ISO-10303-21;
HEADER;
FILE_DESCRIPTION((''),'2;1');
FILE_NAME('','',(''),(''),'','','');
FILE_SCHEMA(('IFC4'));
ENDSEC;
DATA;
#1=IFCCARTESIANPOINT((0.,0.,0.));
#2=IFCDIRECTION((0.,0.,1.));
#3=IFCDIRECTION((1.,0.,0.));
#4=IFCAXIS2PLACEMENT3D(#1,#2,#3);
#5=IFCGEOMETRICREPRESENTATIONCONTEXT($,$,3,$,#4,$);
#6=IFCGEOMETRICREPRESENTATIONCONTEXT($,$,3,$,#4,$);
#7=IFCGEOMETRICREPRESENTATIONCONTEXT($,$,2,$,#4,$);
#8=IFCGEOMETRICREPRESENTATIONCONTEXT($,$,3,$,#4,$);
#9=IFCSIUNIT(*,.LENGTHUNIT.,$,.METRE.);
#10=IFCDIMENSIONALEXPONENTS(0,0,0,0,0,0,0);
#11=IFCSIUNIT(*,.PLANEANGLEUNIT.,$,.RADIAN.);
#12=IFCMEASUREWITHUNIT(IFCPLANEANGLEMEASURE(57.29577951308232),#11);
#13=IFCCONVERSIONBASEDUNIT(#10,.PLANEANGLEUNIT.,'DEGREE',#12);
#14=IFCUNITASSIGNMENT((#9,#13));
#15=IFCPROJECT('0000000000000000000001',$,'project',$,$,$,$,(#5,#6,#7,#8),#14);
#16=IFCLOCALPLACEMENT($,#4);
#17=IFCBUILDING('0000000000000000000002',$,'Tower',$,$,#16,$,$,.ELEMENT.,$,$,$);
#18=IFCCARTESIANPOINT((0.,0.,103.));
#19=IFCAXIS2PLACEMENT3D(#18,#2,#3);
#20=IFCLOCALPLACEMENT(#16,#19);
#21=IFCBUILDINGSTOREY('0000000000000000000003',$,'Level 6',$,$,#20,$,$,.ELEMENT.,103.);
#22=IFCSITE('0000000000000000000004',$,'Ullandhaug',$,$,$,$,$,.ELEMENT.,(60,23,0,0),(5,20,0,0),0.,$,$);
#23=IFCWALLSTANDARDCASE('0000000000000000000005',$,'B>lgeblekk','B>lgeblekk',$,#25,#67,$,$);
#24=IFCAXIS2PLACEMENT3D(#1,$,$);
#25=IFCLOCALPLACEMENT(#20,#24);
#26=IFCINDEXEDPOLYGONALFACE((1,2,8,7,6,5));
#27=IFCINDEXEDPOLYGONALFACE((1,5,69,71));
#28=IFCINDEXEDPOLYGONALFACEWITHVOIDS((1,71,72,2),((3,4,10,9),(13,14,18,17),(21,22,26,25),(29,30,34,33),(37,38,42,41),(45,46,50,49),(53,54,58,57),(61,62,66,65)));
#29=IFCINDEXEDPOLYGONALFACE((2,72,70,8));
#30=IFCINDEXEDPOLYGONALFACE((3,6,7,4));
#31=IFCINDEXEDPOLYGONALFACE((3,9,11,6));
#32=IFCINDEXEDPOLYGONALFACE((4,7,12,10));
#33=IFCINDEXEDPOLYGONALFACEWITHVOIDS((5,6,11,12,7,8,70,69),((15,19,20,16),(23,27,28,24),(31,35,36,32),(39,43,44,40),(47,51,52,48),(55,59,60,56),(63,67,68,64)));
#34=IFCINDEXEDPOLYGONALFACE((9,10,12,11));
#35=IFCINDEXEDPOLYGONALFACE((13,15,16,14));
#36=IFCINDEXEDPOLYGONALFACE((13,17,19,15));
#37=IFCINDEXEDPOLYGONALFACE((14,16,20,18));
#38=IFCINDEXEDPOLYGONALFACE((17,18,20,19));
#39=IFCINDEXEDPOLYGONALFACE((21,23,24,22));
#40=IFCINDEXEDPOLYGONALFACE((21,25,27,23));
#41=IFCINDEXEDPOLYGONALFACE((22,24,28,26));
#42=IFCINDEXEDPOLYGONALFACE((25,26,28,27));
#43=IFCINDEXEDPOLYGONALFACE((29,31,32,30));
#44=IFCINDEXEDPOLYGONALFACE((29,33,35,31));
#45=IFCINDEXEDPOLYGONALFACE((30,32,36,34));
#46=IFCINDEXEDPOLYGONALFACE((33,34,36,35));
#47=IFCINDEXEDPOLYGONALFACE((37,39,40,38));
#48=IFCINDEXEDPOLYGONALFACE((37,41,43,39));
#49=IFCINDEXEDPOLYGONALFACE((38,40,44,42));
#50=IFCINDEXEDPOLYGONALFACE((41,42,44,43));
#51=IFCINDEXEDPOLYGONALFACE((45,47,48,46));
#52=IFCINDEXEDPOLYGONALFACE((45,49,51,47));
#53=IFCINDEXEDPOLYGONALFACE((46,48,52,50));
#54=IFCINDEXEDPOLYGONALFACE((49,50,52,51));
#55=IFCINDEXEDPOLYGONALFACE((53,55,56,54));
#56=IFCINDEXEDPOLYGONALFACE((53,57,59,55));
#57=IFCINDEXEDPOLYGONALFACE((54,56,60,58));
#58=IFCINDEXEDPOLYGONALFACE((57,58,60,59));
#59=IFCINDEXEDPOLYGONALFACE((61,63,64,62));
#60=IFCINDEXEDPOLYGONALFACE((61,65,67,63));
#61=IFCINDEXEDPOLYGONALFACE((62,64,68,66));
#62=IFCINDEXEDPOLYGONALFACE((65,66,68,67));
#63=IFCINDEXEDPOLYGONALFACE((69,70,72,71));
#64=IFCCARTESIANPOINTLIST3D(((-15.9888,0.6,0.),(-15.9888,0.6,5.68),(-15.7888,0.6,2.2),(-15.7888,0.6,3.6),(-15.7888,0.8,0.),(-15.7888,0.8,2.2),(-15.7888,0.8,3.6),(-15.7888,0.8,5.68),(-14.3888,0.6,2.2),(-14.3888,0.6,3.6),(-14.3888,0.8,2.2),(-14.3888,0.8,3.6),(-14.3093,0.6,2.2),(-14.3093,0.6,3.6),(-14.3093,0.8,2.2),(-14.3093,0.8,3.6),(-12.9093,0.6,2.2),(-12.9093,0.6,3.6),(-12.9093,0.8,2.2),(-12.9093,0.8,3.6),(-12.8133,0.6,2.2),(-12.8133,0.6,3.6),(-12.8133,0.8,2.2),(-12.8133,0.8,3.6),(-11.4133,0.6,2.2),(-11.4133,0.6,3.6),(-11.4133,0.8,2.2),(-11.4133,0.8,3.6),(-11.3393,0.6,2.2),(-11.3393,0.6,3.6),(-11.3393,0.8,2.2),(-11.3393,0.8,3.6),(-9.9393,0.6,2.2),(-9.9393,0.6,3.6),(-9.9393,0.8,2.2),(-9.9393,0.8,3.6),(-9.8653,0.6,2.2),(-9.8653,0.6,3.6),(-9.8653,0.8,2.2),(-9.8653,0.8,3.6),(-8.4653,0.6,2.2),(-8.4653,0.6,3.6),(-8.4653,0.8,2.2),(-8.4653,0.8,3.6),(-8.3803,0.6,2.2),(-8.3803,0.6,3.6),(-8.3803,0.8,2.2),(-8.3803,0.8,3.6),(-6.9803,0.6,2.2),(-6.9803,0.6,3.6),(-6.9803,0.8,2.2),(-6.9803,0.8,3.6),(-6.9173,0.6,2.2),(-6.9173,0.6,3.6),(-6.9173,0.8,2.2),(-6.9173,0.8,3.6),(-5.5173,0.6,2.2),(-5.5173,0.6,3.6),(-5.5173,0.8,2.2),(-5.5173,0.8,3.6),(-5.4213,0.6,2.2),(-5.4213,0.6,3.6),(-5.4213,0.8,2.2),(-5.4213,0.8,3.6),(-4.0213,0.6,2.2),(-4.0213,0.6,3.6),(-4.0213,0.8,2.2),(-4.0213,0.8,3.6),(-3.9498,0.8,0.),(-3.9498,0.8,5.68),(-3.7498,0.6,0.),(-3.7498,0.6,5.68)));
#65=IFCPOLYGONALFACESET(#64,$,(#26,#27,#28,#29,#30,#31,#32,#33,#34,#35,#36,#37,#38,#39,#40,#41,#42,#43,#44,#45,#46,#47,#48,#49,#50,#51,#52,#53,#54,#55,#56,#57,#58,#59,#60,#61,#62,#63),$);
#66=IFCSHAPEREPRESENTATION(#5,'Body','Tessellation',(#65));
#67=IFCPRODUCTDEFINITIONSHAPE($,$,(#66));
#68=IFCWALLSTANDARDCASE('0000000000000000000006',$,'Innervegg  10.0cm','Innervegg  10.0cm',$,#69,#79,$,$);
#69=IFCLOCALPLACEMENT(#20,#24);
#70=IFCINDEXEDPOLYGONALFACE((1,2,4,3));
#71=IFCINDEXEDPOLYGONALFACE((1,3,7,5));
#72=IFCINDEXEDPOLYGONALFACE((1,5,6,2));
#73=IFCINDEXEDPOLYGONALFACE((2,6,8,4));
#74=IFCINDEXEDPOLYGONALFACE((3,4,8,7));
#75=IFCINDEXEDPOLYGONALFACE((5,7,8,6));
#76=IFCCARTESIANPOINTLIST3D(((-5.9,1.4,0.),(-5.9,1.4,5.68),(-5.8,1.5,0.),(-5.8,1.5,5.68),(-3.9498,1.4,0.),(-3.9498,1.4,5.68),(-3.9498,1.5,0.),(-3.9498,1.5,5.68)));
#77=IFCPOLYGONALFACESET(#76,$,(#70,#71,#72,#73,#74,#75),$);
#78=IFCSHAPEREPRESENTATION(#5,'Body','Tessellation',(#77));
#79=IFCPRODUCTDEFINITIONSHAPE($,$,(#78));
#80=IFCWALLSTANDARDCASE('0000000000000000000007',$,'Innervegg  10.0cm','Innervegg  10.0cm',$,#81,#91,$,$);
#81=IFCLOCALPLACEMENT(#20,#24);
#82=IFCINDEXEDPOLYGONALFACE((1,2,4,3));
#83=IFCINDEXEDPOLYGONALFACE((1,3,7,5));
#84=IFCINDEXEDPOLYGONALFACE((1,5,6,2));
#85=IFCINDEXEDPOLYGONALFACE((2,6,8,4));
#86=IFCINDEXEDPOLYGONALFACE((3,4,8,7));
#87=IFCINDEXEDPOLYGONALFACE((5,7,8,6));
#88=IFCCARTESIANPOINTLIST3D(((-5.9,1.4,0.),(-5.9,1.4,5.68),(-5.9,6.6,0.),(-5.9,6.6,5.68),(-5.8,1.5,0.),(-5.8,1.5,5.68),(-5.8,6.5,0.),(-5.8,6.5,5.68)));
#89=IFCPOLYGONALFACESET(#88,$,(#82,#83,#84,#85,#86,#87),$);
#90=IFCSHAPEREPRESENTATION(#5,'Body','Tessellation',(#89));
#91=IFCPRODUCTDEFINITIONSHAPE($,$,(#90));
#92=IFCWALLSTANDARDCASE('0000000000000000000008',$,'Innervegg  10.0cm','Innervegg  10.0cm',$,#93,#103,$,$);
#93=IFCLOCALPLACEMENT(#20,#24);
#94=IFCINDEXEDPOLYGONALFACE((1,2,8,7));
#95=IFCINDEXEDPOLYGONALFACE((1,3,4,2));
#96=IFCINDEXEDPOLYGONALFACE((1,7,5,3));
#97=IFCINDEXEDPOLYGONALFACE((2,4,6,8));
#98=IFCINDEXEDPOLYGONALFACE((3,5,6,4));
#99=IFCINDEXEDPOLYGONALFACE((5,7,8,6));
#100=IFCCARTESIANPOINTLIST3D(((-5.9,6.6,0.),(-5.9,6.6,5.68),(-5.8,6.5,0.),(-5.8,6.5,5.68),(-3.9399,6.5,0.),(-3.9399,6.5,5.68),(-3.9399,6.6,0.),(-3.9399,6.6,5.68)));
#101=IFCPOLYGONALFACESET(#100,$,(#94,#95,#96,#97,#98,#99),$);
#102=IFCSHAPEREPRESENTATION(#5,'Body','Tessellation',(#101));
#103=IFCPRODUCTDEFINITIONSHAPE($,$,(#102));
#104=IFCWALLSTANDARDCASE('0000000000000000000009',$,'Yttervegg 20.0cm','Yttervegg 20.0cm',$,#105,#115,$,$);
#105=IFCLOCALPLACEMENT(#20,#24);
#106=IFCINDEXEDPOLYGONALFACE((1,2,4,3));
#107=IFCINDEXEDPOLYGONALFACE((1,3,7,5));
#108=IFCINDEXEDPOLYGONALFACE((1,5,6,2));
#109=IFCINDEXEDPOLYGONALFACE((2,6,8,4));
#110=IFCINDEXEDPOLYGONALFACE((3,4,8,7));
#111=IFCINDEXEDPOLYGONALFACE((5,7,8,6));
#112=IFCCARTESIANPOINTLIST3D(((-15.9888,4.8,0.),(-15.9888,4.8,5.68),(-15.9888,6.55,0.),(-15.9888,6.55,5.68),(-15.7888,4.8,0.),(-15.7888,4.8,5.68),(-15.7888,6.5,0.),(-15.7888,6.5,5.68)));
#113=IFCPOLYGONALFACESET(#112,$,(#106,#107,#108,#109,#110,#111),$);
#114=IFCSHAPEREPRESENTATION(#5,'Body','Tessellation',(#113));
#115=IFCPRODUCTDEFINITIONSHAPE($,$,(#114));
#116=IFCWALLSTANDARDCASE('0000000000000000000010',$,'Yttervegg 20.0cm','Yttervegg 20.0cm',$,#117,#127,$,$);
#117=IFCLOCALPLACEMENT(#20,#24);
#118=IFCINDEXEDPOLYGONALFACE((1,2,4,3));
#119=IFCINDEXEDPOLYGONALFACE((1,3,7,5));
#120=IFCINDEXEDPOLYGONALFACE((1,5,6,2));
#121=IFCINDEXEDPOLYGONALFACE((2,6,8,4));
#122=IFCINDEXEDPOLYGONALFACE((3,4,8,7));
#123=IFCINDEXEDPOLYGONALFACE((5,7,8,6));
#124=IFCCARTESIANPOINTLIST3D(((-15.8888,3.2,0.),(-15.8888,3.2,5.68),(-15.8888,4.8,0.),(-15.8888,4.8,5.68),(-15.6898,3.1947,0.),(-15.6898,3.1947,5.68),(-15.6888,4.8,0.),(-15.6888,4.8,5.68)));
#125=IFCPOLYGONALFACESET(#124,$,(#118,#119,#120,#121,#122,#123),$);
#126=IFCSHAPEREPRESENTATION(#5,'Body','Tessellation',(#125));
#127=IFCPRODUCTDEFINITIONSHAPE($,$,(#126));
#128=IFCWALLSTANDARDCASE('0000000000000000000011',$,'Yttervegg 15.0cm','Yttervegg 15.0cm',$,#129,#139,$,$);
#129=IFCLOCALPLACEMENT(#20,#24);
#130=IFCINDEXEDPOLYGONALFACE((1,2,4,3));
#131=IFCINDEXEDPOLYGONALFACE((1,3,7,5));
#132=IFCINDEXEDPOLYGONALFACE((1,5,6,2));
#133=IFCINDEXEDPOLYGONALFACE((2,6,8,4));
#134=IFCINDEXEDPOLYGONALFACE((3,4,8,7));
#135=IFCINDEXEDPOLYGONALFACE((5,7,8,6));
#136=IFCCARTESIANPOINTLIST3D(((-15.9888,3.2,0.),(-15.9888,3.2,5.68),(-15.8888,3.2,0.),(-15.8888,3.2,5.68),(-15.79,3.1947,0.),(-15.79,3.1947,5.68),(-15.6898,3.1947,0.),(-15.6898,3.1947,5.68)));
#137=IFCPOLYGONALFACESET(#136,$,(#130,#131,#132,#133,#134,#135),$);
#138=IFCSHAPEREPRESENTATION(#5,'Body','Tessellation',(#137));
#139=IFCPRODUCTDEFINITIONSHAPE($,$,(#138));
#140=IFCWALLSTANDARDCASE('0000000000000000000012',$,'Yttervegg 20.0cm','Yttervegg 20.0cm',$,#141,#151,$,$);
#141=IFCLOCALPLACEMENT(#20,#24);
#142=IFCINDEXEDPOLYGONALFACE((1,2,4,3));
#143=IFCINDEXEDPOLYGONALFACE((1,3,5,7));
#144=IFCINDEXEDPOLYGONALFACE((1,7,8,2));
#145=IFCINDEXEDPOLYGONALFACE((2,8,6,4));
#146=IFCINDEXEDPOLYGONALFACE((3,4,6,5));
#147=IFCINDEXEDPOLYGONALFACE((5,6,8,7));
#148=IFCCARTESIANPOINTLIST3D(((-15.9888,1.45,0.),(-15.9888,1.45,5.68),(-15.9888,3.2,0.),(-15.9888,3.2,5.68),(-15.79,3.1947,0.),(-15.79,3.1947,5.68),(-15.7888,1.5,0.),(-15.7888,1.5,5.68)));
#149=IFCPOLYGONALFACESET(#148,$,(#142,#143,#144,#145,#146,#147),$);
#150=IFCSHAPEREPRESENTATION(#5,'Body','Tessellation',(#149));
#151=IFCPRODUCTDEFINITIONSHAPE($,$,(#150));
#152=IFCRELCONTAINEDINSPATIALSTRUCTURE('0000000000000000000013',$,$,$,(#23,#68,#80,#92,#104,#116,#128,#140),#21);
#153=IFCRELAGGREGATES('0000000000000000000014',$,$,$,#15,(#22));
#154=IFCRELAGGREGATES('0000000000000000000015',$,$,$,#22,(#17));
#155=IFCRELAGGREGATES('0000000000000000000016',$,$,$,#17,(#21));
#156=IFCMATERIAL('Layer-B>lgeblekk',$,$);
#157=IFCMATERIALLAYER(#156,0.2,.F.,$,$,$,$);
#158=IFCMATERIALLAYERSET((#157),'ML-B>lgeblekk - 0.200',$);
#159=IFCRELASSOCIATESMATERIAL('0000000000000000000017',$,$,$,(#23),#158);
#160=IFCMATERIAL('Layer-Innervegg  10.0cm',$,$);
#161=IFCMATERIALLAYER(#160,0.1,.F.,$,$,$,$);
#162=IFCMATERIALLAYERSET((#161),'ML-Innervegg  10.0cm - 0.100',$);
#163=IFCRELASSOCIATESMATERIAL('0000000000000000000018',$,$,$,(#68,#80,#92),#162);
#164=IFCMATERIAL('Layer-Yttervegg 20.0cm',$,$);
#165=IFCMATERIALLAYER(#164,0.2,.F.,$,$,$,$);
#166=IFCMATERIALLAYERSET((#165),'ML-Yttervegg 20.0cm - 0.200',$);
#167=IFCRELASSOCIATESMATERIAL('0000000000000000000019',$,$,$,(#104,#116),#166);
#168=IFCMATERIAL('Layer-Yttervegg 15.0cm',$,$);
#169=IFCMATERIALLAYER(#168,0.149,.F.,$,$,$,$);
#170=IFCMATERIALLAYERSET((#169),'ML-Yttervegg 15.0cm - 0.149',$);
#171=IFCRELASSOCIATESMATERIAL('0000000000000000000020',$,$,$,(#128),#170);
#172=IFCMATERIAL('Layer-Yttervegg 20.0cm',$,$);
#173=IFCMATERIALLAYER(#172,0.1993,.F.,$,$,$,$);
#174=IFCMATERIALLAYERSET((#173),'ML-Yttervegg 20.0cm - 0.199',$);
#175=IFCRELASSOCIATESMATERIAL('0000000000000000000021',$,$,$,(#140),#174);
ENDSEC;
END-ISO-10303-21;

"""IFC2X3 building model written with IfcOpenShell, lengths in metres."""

from ifc_helpers import new_model, entity, si_unit, converted_unit, frame, origin_with_axes, place, context, project, spatial, polyline, outline, extrude, material, layer, layer_set, layer_usage, element, save


model = new_model("IFC2X3")

# Units and contexts
context_of_model_1 = context(None, 3, world=origin_with_axes())
context_of_model_2 = context(None, 3, world=origin_with_axes())
context_of_model_3 = context(None, 2, world=origin_with_axes())
context_of_model_4 = context(None, 3, world=origin_with_axes())
ifc_project = project(units=[si_unit("LENGTHUNIT", "METRE"), converted_unit("PLANEANGLEUNIT", "DEGREE", entity("IfcPlaneAngleMeasure", 57.29577951308232), si_unit("PLANEANGLEUNIT", "RADIAN"), dimensions=[0, 0, 0, 0, 0, 0, 0])], contexts=[context_of_model_1, context_of_model_2, context_of_model_3, context_of_model_4])

# Site, building, storey
site = spatial("IfcSite", under=ifc_project, Name="Ullandhaug", CompositionType="ELEMENT", RefLatitude=(60, 23, 0, 0), RefLongitude=(5, 20, 0, 0), RefElevation=0.0)
building_placement = place(None, origin_with_axes())
building = spatial("IfcBuilding", under=site, at=building_placement, Name="Tower", CompositionType="ELEMENT")
storey_placement = place(building_placement, frame((0.0, 0.0, 103.0), z_axis=(0.0, 0.0, 1.0), x_axis=(1.0, 0.0, 0.0)))
storey = spatial("IfcBuildingStorey", under=building, at=storey_placement, Name="Level 6", CompositionType="ELEMENT", Elevation=103.0)

# Shared definitions
ifc_material_1 = material(Name="Layer-Innervegg  10.0cm")
ifc_layer_1 = layer(ifc_material_1, 0.1, ventilated=False)
ifc_layer_set_1 = layer_set([ifc_layer_1], Name="ML-Innervegg  10.0cm - 0.100")
ifc_layer_usage_1 = layer_usage(ifc_layer_set_1, "AXIS2", "POSITIVE", 0.0)

# Wall, openings
ifc_material_2 = material(Name="Layer-B>lgeblekk")
ifc_layer_2 = layer(ifc_material_2, 0.2, ventilated=False)
ifc_layer_set_2 = layer_set([ifc_layer_2], Name="ML-B>lgeblekk - 0.200")
ifc_layer_usage_2 = layer_usage(ifc_layer_set_2, "AXIS2", "POSITIVE", 0.0)
wall_1_placement = place(storey_placement, frame((-15.9888, 0.6, 0.0), z_axis=(0.0, 0.0, 1.0), x_axis=(1.0, 0.0, 0.0)))
wall_1 = element("IfcWallStandardCase", 1, at=wall_1_placement, inside=storey, material=ifc_layer_usage_2, Name="B>lgeblekk", Description="B>lgeblekk", context=context_of_model_1, shape_type="SweptSolid", body=[
    extrude(outline(polyline([(0.0, 0.0), (12.2391, 0.0), (12.0391, 0.2), (0.2, 0.2), (0.0, 0.0)])), origin_with_axes(), (0.0, 0.0, 1.0), 5.68),
])
opening_1_placement = place(wall_1_placement, frame((0.2, 0.2, 2.2), z_axis=(0.0, 0.0, 1.0), x_axis=(1.0, 0.0, 0.0)))
element("IfcOpeningElement", 2, at=opening_1_placement, cuts=wall_1, context=context_of_model_1, shape_type="SweptSolid", body=[
    extrude(outline(polyline([(0.0, 0.0), (1.4, 0.0), (1.4, 1.4), (0.0, 1.4), (0.0, 0.0)])), frame((0.0, 0.0, 0.0), z_axis=(0.0, 1.0, 0.0), x_axis=(0.0, 0.0, 1.0)), (0.0, 0.0, -1.0), 0.2),
])
opening_2_placement = place(wall_1_placement, frame((1.6796, 0.2, 2.2), z_axis=(0.0, 0.0, 1.0), x_axis=(1.0, 0.0, 0.0)))
element("IfcOpeningElement", 3, at=opening_2_placement, cuts=wall_1, context=context_of_model_1, shape_type="SweptSolid", body=[
    extrude(outline(polyline([(0.0, 0.0), (1.4, 0.0), (1.4, 1.4), (0.0, 1.4), (0.0, 0.0)])), frame((0.0, 0.0, 0.0), z_axis=(0.0, 1.0, 0.0), x_axis=(0.0, 0.0, 1.0)), (0.0, 0.0, -1.0), 0.2),
])
opening_3_placement = place(wall_1_placement, frame((3.1756, 0.2, 2.2), z_axis=(0.0, 0.0, 1.0), x_axis=(1.0, 0.0, 0.0)))
element("IfcOpeningElement", 4, at=opening_3_placement, cuts=wall_1, context=context_of_model_1, shape_type="SweptSolid", body=[
    extrude(outline(polyline([(0.0, 0.0), (1.4, 0.0), (1.4, 1.4), (0.0, 1.4), (0.0, 0.0)])), frame((0.0, 0.0, 0.0), z_axis=(0.0, 1.0, 0.0), x_axis=(0.0, 0.0, 1.0)), (0.0, 0.0, -1.0), 0.2),
])
opening_4_placement = place(wall_1_placement, frame((4.6496, 0.2, 2.2), z_axis=(0.0, 0.0, 1.0), x_axis=(1.0, 0.0, 0.0)))
element("IfcOpeningElement", 5, at=opening_4_placement, cuts=wall_1, context=context_of_model_1, shape_type="SweptSolid", body=[
    extrude(outline(polyline([(0.0, 0.0), (1.4, 0.0), (1.4, 1.4), (0.0, 1.4), (0.0, 0.0)])), frame((0.0, 0.0, 0.0), z_axis=(0.0, 1.0, 0.0), x_axis=(0.0, 0.0, 1.0)), (0.0, 0.0, -1.0), 0.2),
])
opening_5_placement = place(wall_1_placement, frame((6.1236, 0.2, 2.2), z_axis=(0.0, 0.0, 1.0), x_axis=(1.0, 0.0, 0.0)))
element("IfcOpeningElement", 6, at=opening_5_placement, cuts=wall_1, context=context_of_model_1, shape_type="SweptSolid", body=[
    extrude(outline(polyline([(0.0, 0.0), (1.4, 0.0), (1.4, 1.4), (0.0, 1.4), (0.0, 0.0)])), frame((0.0, 0.0, 0.0), z_axis=(0.0, 1.0, 0.0), x_axis=(0.0, 0.0, 1.0)), (0.0, 0.0, -1.0), 0.2),
])
opening_6_placement = place(wall_1_placement, frame((7.6086, 0.2, 2.2), z_axis=(0.0, 0.0, 1.0), x_axis=(1.0, 0.0, 0.0)))
element("IfcOpeningElement", 7, at=opening_6_placement, cuts=wall_1, context=context_of_model_1, shape_type="SweptSolid", body=[
    extrude(outline(polyline([(0.0, 0.0), (1.4, 0.0), (1.4, 1.4), (0.0, 1.4), (0.0, 0.0)])), frame((0.0, 0.0, 0.0), z_axis=(0.0, 1.0, 0.0), x_axis=(0.0, 0.0, 1.0)), (0.0, 0.0, -1.0), 0.2),
])
opening_7_placement = place(wall_1_placement, frame((9.0716, 0.2, 2.2), z_axis=(0.0, 0.0, 1.0), x_axis=(1.0, 0.0, 0.0)))
element("IfcOpeningElement", 8, at=opening_7_placement, cuts=wall_1, context=context_of_model_1, shape_type="SweptSolid", body=[
    extrude(outline(polyline([(0.0, 0.0), (1.4, 0.0), (1.4, 1.4), (0.0, 1.4), (0.0, 0.0)])), frame((0.0, 0.0, 0.0), z_axis=(0.0, 1.0, 0.0), x_axis=(0.0, 0.0, 1.0)), (0.0, 0.0, -1.0), 0.2),
])
opening_8_placement = place(wall_1_placement, frame((10.5676, 0.2, 2.2), z_axis=(0.0, 0.0, 1.0), x_axis=(1.0, 0.0, 0.0)))
element("IfcOpeningElement", 9, at=opening_8_placement, cuts=wall_1, context=context_of_model_1, shape_type="SweptSolid", body=[
    extrude(outline(polyline([(0.0, 0.0), (1.4, 0.0), (1.4, 1.4), (0.0, 1.4), (0.0, 0.0)])), frame((0.0, 0.0, 0.0), z_axis=(0.0, 1.0, 0.0), x_axis=(0.0, 0.0, 1.0)), (0.0, 0.0, -1.0), 0.2),
])

# Walls
wall_2_placement = place(storey_placement, frame((-3.9498, 1.5, 0.0), z_axis=(0.0, 0.0, 1.0), x_axis=(-1.0, 0.0, 0.0)))
element("IfcWallStandardCase", 10, at=wall_2_placement, inside=storey, material=ifc_layer_usage_1, Name="Innervegg  10.0cm", Description="Innervegg  10.0cm", context=context_of_model_1, shape_type="SweptSolid", body=[
    extrude(outline(polyline([(0.0, 0.0), (1.8502, 0.0), (1.9502, 0.1), (0.0, 0.1), (0.0, 0.0)])), frame((0.0, 0.0, 0.0), z_axis=(0.0, 0.0, 1.0), x_axis=(1.0, 0.0, 0.0)), (0.0, 0.0, 1.0), 5.68),
])
wall_3_placement = place(storey_placement, frame((-5.8, 1.5, 0.0), z_axis=(0.0, 0.0, 1.0), x_axis=(0.0, 1.0, 0.0)))
element("IfcWallStandardCase", 11, at=wall_3_placement, inside=storey, material=ifc_layer_usage_1, Name="Innervegg  10.0cm", Description="Innervegg  10.0cm", context=context_of_model_1, shape_type="SweptSolid", body=[
    extrude(outline(polyline([(0.0, 0.0), (5.0, 0.0), (5.1, 0.1), (-0.1, 0.1), (0.0, 0.0)])), frame((0.0, 0.0, 0.0), z_axis=(0.0, 0.0, 1.0), x_axis=(1.0, 0.0, 0.0)), (0.0, 0.0, 1.0), 5.68),
])
wall_4_placement = place(storey_placement, frame((-5.8, 6.5, 0.0), z_axis=(0.0, 0.0, 1.0), x_axis=(1.0, 0.0, 0.0)))
element("IfcWallStandardCase", 12, at=wall_4_placement, inside=storey, material=ifc_layer_usage_1, Name="Innervegg  10.0cm", Description="Innervegg  10.0cm", context=context_of_model_1, shape_type="SweptSolid", body=[
    extrude(outline(polyline([(0.0, 0.0), (1.8601, 0.0), (1.8601, 0.1), (-0.1, 0.1), (0.0, 0.0)])), origin_with_axes(), (0.0, 0.0, 1.0), 5.68),
])
ifc_material_3 = material(Name="Layer-Yttervegg 20.0cm")
ifc_layer_3 = layer(ifc_material_3, 0.2, ventilated=False)
ifc_layer_set_3 = layer_set([ifc_layer_3], Name="ML-Yttervegg 20.0cm - 0.200")
ifc_layer_usage_3 = layer_usage(ifc_layer_set_3, "AXIS2", "POSITIVE", 0.0)
wall_5_placement = place(storey_placement, frame((-15.9888, 6.55, 0.0), z_axis=(0.0, 0.0, 1.0), x_axis=(0.0, -1.0, 0.0)))
element("IfcWallStandardCase", 13, at=wall_5_placement, inside=storey, material=ifc_layer_usage_3, Name="Yttervegg 20.0cm", Description="Yttervegg 20.0cm", context=context_of_model_1, shape_type="SweptSolid", body=[
    extrude(outline(polyline([(0.0, 0.0), (1.75, 0.0), (1.75, 0.2), (0.05, 0.2), (0.0, 0.0)])), frame((0.0, 0.0, 0.0), z_axis=(0.0, 0.0, 1.0), x_axis=(1.0, 0.0, 0.0)), (0.0, 0.0, 1.0), 5.68),
])
wall_6_placement = place(storey_placement, frame((-15.8888, 4.8, 0.0), z_axis=(0.0, 0.0, 1.0), x_axis=(0.000001, -1.0, 0.0)))
element("IfcWallStandardCase", 14, at=wall_6_placement, inside=storey, material=ifc_layer_usage_3, Name="Yttervegg 20.0cm", Description="Yttervegg 20.0cm", context=context_of_model_1, shape_type="SweptSolid", body=[
    extrude(outline(polyline([(0.0, 0.0), (1.6, 0.0), (1.6053, 0.199), (0.0, 0.2), (0.0, 0.0)])), frame((0.0, 0.0, 0.0), z_axis=(0.0, 0.0, 1.0), x_axis=(1.0, 0.0, 0.0)), (0.0, 0.0, 1.0), 5.68),
])
ifc_material_4 = material(Name="Layer-Yttervegg 15.0cm")
ifc_layer_4 = layer(ifc_material_4, 0.149, ventilated=False)
ifc_layer_set_4 = layer_set([ifc_layer_4], Name="ML-Yttervegg 15.0cm - 0.149")
ifc_layer_usage_4 = layer_usage(ifc_layer_set_4, "AXIS2", "POSITIVE", 0.0)
wall_7_placement = place(storey_placement, frame((-15.8888, 3.2, 0.0), z_axis=(0.0, 0.0, 1.0), x_axis=(-1.0, 0.0, 0.0)))
element("IfcWallStandardCase", 15, at=wall_7_placement, inside=storey, material=ifc_layer_usage_4, Name="Yttervegg 15.0cm", Description="Yttervegg 15.0cm", context=context_of_model_1, shape_type="SweptSolid", body=[
    extrude(outline(polyline([(0.0, 0.0), (0.1, 0.0), (-0.0989, 0.0053), (-0.199, 0.0053), (0.0, 0.0)])), frame((0.0, 0.0, 0.0), z_axis=(0.0, 0.0, 1.0), x_axis=(1.0, 0.0, 0.0)), (0.0, 0.0, 1.0), 5.68),
])
ifc_material_5 = material(Name="Layer-Yttervegg 20.0cm")
ifc_layer_5 = layer(ifc_material_5, 0.1993, ventilated=False)
ifc_layer_set_5 = layer_set([ifc_layer_5], Name="ML-Yttervegg 20.0cm - 0.199")
ifc_layer_usage_5 = layer_usage(ifc_layer_set_5, "AXIS2", "POSITIVE", 0.0)
wall_8_placement = place(storey_placement, frame((-15.9888, 3.2, 0.0), z_axis=(0.0, 0.0, 1.0), x_axis=(0.0, -1.0, 0.0)))
element("IfcWallStandardCase", 16, at=wall_8_placement, inside=storey, material=ifc_layer_usage_5, Name="Yttervegg 20.0cm", Description="Yttervegg 20.0cm", context=context_of_model_1, shape_type="SweptSolid", body=[
    extrude(outline(polyline([(0.0, 0.0), (1.75, 0.0), (1.7, 0.2), (0.0053, 0.1989), (0.0, 0.0)])), frame((0.0, 0.0, 0.0), z_axis=(0.0, 0.0, 1.0), x_axis=(1.0, 0.0, 0.0)), (0.0, 0.0, 1.0), 5.68),
])

save(model, "model.ifc")
